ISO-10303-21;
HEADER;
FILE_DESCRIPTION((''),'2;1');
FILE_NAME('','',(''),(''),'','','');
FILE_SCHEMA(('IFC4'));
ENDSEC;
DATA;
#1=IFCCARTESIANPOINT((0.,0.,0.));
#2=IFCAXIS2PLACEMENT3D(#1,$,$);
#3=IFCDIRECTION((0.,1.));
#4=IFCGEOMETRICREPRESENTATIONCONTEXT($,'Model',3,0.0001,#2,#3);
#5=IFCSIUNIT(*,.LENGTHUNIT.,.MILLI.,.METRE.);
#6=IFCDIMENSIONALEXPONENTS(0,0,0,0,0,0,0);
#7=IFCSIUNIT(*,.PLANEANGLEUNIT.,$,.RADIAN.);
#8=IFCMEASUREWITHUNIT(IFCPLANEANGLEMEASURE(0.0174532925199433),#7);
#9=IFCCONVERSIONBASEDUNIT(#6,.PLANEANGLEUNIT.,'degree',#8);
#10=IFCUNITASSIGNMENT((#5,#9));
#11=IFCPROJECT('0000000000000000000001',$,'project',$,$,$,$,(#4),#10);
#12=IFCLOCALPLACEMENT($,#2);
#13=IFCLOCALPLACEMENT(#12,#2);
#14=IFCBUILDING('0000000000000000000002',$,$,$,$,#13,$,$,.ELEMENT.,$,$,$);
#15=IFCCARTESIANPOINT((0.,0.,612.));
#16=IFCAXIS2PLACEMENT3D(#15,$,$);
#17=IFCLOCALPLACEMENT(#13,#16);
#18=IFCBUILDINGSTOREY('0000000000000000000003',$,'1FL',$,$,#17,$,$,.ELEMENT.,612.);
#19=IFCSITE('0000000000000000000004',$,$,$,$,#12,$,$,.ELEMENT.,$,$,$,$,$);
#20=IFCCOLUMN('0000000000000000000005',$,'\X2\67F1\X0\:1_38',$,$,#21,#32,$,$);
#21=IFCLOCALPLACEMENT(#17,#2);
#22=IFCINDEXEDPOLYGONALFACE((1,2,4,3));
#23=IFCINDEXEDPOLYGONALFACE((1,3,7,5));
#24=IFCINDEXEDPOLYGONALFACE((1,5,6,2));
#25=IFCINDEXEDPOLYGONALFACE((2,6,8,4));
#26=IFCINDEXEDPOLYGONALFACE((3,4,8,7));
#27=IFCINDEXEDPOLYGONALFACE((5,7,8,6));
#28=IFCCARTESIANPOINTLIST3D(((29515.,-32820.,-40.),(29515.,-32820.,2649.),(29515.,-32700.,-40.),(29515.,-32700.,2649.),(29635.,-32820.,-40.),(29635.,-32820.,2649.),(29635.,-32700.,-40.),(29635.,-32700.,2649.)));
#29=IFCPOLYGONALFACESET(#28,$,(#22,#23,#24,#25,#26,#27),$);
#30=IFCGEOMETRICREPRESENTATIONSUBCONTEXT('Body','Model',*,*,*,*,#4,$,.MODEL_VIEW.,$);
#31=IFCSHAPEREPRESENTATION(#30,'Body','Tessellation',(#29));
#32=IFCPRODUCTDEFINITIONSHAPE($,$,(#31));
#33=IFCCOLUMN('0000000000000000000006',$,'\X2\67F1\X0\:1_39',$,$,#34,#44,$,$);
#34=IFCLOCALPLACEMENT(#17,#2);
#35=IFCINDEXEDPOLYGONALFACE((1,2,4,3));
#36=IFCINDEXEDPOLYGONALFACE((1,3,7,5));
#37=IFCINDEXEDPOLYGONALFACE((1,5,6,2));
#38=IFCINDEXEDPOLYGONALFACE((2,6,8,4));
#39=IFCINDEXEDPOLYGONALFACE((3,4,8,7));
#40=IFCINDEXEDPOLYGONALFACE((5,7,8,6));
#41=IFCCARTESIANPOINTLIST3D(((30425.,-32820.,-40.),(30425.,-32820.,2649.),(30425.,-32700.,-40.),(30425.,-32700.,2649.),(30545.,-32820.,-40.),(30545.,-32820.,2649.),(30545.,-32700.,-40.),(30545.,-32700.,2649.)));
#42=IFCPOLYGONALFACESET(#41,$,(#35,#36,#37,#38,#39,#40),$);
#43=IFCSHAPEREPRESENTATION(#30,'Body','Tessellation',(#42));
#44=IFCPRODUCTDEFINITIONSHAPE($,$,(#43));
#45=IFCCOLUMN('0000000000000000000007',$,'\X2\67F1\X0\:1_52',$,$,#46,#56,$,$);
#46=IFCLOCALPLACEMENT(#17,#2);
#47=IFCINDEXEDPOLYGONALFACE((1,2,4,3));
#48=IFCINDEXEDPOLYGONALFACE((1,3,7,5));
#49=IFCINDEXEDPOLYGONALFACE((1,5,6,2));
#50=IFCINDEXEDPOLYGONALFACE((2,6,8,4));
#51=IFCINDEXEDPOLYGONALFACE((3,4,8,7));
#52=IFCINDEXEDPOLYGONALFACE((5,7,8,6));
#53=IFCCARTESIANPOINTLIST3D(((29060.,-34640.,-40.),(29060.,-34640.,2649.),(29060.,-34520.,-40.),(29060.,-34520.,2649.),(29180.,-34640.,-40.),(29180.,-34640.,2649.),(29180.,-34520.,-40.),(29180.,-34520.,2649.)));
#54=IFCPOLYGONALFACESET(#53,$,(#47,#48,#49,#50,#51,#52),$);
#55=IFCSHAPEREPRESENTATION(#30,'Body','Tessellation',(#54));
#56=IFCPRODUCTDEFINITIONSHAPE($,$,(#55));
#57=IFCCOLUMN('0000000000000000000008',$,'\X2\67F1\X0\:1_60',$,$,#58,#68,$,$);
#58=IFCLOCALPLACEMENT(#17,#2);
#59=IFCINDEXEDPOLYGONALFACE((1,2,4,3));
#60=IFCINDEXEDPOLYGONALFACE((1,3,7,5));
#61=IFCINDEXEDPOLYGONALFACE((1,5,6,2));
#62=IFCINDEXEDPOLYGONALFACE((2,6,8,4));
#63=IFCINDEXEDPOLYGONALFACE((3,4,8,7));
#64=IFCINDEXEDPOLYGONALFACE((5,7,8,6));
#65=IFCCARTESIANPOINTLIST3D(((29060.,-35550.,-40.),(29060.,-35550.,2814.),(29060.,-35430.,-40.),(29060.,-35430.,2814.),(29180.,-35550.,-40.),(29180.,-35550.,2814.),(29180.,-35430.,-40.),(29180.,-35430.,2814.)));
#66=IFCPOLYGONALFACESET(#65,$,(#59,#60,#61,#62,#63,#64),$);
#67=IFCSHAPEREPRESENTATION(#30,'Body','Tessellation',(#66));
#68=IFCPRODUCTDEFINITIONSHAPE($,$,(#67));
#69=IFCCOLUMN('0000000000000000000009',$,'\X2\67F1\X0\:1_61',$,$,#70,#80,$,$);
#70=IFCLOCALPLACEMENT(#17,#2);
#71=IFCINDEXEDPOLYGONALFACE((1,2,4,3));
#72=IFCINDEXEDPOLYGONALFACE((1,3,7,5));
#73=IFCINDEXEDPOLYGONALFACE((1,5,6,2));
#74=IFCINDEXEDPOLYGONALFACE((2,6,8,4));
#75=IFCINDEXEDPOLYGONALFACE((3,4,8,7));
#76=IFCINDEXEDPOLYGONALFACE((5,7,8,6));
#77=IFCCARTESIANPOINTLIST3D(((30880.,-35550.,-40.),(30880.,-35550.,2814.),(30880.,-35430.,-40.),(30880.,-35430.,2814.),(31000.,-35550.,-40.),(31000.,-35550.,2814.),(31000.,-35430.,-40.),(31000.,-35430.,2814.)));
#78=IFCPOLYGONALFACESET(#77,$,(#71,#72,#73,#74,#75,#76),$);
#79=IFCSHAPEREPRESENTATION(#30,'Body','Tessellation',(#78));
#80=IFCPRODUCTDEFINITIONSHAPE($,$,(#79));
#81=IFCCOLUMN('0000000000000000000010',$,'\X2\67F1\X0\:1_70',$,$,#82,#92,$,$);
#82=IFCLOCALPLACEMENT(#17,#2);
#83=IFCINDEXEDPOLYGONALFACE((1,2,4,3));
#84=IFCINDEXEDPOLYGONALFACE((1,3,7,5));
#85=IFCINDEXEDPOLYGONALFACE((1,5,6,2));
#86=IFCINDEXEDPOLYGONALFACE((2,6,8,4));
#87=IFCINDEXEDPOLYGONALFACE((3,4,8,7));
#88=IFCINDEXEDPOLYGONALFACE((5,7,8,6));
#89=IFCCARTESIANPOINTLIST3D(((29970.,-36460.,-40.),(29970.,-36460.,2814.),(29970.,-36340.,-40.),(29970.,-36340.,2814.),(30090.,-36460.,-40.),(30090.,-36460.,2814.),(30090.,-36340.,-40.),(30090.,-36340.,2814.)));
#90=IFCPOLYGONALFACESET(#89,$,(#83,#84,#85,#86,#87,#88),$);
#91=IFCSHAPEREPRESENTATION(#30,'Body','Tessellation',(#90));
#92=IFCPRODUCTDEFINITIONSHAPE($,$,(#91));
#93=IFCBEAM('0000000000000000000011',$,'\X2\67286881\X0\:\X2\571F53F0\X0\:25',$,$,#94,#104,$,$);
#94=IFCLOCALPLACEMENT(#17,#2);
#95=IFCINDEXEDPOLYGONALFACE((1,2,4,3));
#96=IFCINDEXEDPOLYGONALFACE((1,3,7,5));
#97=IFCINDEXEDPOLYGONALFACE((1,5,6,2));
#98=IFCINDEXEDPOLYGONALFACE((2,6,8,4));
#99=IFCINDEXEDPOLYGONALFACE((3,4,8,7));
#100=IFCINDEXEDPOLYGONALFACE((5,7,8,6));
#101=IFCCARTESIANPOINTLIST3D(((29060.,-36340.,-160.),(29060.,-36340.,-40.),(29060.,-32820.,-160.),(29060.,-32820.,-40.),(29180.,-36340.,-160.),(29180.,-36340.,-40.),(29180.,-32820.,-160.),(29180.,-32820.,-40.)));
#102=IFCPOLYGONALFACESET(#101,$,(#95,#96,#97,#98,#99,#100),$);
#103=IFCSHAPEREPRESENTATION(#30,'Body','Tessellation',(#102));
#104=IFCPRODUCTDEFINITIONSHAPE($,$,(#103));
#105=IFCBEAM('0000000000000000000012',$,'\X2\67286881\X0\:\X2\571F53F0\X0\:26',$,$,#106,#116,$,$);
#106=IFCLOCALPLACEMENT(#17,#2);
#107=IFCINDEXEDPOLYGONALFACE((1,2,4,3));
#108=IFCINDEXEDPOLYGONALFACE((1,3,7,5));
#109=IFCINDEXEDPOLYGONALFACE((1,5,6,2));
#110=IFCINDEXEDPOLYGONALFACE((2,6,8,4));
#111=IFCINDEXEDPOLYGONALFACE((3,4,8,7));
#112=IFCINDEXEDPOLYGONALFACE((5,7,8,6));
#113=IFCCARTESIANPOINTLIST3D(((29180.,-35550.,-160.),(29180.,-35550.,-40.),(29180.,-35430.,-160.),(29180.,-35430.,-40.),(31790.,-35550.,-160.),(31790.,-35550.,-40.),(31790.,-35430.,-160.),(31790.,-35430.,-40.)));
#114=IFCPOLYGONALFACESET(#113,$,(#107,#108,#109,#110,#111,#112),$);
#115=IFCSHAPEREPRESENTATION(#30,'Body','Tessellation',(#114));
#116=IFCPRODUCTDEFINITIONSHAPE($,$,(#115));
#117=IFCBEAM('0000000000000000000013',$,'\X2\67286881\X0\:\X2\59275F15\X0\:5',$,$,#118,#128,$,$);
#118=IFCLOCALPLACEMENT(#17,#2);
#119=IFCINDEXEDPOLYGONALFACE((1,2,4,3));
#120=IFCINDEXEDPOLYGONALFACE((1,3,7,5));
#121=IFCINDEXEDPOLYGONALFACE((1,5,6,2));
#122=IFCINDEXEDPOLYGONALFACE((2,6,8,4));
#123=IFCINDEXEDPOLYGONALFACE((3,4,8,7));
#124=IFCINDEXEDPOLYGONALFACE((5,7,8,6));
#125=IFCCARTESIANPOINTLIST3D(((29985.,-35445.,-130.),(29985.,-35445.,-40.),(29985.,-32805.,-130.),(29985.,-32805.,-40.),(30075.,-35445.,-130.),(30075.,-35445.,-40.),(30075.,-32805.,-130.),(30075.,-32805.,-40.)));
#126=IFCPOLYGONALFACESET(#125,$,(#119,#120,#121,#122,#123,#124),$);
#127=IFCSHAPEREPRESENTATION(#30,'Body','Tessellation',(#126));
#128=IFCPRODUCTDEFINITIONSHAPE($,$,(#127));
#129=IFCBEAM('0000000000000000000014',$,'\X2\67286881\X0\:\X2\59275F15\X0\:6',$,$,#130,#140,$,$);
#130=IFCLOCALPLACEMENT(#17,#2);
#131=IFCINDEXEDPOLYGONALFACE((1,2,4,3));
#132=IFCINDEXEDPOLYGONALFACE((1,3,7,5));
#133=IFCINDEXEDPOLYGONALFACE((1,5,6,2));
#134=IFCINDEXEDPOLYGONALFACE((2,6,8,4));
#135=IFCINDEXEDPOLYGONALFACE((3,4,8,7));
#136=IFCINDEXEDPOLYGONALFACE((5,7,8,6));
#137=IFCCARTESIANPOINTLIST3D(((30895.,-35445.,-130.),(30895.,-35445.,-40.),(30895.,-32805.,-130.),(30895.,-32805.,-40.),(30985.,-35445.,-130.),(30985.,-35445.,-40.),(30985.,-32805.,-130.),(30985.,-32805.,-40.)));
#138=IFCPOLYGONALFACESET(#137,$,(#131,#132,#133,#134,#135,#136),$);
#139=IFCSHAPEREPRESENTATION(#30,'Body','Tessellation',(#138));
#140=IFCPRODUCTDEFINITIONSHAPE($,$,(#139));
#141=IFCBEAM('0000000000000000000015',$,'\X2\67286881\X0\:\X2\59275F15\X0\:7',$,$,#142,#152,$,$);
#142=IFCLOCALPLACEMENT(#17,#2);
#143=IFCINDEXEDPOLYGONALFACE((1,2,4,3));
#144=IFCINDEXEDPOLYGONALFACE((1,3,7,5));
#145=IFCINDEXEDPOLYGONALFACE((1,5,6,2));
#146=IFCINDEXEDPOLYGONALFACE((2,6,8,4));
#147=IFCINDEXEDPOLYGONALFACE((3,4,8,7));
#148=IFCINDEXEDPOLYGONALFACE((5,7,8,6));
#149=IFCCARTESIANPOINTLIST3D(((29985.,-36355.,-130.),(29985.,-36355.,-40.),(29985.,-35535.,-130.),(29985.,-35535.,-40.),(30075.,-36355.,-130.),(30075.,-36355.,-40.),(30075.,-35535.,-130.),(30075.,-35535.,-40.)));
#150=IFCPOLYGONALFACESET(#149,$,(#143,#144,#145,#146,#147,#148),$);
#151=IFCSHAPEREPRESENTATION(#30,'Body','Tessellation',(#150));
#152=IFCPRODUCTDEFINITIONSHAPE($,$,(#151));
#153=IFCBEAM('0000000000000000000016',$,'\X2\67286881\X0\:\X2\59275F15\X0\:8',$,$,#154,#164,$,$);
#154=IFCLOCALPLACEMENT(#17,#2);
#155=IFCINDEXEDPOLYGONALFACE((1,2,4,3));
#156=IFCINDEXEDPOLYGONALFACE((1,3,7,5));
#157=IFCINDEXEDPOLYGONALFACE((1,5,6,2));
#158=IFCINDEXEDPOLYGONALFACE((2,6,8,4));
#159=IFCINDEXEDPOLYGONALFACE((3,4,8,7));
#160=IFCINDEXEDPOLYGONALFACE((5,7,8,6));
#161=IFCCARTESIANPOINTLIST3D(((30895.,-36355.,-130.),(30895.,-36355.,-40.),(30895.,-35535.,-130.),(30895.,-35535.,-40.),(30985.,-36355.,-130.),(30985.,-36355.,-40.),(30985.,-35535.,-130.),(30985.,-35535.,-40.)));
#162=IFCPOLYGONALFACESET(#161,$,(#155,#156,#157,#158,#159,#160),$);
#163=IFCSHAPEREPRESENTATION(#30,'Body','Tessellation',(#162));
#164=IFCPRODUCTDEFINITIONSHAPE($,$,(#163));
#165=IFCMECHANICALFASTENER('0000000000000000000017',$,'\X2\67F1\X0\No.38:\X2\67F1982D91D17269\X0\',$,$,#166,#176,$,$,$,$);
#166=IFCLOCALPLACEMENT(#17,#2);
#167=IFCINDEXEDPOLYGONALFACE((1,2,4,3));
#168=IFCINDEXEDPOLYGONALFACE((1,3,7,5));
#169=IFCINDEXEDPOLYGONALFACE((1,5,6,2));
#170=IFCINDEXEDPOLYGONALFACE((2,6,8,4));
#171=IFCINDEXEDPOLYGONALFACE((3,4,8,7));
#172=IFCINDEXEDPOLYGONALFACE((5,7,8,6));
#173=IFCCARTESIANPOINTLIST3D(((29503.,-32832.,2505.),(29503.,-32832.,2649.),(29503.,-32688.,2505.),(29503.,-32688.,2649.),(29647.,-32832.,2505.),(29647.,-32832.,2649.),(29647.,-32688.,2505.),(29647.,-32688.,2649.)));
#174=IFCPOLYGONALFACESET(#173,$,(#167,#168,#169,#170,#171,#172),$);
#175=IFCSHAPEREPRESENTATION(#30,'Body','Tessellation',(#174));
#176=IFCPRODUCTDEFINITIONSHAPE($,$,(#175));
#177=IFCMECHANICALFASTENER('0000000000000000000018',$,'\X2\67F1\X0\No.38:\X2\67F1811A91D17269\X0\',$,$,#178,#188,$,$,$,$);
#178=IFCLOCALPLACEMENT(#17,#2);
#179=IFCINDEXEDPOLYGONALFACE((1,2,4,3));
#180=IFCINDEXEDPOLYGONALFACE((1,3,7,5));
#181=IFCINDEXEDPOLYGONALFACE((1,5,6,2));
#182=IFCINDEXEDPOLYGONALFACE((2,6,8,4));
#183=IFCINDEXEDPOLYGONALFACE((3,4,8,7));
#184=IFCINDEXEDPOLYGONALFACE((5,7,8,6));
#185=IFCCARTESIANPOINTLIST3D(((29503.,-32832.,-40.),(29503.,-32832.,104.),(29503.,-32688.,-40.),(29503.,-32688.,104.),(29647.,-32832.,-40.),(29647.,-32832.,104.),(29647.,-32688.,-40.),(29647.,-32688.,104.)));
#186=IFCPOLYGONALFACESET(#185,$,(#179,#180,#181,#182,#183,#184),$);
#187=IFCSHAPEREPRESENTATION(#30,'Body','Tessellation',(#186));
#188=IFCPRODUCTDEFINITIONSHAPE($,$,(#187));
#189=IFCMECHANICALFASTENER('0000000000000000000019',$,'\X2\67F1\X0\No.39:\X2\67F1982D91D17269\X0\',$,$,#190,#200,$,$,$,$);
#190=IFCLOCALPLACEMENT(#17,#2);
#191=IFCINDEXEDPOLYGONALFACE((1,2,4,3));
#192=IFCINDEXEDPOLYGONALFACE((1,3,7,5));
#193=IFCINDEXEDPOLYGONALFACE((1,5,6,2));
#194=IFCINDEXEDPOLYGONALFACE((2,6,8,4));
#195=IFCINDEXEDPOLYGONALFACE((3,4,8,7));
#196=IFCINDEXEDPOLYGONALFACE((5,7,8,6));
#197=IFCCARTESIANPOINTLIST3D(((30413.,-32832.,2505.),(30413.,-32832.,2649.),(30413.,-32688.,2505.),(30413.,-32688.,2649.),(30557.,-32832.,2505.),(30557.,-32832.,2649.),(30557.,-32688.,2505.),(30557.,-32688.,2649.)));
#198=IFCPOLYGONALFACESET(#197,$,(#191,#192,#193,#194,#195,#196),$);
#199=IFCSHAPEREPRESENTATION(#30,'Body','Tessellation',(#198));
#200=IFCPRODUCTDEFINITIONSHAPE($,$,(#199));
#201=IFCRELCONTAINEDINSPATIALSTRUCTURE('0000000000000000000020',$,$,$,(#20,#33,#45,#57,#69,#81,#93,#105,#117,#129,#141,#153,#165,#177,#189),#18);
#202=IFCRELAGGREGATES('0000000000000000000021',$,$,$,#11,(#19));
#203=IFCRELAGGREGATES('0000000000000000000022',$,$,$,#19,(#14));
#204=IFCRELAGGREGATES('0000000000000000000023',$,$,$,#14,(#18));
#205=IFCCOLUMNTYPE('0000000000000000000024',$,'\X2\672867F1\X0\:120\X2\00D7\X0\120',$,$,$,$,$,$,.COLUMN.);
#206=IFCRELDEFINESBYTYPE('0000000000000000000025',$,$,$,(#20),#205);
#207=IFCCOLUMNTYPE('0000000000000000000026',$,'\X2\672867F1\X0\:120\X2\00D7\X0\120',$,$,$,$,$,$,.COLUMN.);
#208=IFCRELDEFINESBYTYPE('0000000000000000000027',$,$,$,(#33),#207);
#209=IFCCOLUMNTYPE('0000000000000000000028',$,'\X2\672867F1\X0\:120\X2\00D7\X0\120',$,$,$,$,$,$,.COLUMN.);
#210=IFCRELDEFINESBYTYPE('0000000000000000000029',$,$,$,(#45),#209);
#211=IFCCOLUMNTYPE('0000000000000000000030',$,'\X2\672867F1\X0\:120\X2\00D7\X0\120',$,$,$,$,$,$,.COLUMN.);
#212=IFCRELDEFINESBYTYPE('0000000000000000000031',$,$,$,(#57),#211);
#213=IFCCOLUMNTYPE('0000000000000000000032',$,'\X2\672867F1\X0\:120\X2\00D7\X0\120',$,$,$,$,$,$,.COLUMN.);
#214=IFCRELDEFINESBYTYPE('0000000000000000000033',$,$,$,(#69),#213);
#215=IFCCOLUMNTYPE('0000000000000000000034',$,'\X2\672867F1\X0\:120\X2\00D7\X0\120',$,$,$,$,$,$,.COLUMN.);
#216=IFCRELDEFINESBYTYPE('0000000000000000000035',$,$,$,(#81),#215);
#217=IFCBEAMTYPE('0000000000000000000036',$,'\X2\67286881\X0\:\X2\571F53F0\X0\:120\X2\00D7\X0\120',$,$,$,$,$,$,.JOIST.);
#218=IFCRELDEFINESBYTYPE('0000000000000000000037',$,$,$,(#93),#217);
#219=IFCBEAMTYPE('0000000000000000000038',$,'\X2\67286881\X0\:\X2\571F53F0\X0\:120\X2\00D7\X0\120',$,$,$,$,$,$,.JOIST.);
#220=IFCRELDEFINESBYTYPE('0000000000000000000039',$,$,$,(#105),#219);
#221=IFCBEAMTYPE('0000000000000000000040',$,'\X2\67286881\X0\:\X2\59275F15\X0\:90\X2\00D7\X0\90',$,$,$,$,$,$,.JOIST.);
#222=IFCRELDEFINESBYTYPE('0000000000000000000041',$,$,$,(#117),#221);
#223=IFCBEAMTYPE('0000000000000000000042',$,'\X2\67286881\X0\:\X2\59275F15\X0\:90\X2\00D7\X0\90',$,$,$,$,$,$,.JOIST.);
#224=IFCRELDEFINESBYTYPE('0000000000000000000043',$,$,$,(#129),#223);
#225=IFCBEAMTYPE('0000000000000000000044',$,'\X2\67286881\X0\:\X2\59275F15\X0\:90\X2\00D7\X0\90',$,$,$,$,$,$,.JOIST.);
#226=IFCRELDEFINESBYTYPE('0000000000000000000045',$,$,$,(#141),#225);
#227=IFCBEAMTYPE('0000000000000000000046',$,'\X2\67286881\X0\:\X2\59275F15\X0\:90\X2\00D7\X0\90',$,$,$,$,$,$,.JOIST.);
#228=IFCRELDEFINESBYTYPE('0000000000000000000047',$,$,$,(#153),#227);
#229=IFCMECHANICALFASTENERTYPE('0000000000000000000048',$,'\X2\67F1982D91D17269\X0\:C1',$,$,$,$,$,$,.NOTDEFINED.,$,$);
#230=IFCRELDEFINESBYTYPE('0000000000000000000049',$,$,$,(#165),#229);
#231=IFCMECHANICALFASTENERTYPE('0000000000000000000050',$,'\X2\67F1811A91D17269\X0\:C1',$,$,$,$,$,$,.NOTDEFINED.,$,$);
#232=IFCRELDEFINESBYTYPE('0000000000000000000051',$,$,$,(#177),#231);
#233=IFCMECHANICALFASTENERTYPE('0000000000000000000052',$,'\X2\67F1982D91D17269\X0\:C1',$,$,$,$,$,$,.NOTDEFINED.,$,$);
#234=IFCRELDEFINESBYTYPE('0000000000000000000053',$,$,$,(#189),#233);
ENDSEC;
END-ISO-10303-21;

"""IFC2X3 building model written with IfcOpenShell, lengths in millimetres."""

from ifc_helpers import new_model, entity, si_unit, converted_unit, direction, frame, origin, origin_with_axes, origin_2d, place, context, subcontext, project, spatial, rectangle, extrude, type_object, element, save


model = new_model("IFC2X3")

# Units and contexts
model_context = context("Model", 3, precision=0.0001, world=origin(), true_north=direction((0.0, 1.0)))
body_context = subcontext(model_context, "Body", "Model", "MODEL_VIEW")
ifc_project = project(units=[si_unit("LENGTHUNIT", "METRE", prefix="MILLI"), converted_unit("PLANEANGLEUNIT", "degree", entity("IfcPlaneAngleMeasure", 0.0174532925199433), si_unit("PLANEANGLEUNIT", "RADIAN"), dimensions=[0, 0, 0, 0, 0, 0, 0])], contexts=[model_context])

# Site, building, storey
site_placement = place(None, origin())
site = spatial("IfcSite", under=ifc_project, at=site_placement, CompositionType="ELEMENT")
building_placement = place(site_placement, origin())
building = spatial("IfcBuilding", under=site, at=building_placement, CompositionType="ELEMENT")
storey_placement = place(building_placement, frame((0.0, 0.0, 612.0)))
storey = spatial("IfcBuildingStorey", under=building, at=storey_placement, Name="1FL", CompositionType="ELEMENT", Elevation=612.0)

# Columns
column_type_1 = type_object("IfcColumnType", Name="木柱:120×120", PredefinedType="COLUMN")
column_1_placement = place(storey_placement, frame((29575.0, -32760.0, -40.0)))
element("IfcColumn", 1, at=column_1_placement, inside=storey, type_object=column_type_1, Name="柱:1_38", context=body_context, shape_type="SweptSolid", body=[
    extrude(rectangle(XDim=120.0, YDim=120.0, at=origin_2d()), origin_with_axes(), (0.0, 0.0, 1.0), 2689.0),
])
column_type_2 = type_object("IfcColumnType", Name="木柱:120×120", PredefinedType="COLUMN")
column_2_placement = place(storey_placement, frame((30485.0, -32760.0, -40.0)))
element("IfcColumn", 2, at=column_2_placement, inside=storey, type_object=column_type_2, Name="柱:1_39", context=body_context, shape_type="SweptSolid", body=[
    extrude(rectangle(XDim=120.0, YDim=120.0, at=origin_2d()), origin_with_axes(), (0.0, 0.0, 1.0), 2689.0),
])
column_type_3 = type_object("IfcColumnType", Name="木柱:120×120", PredefinedType="COLUMN")
column_3_placement = place(storey_placement, frame((29120.0, -34580.0, -40.0)))
element("IfcColumn", 3, at=column_3_placement, inside=storey, type_object=column_type_3, Name="柱:1_52", context=body_context, shape_type="SweptSolid", body=[
    extrude(rectangle(XDim=120.0, YDim=120.0, at=origin_2d()), origin_with_axes(), (0.0, 0.0, 1.0), 2689.0),
])
column_type_4 = type_object("IfcColumnType", Name="木柱:120×120", PredefinedType="COLUMN")
column_4_placement = place(storey_placement, frame((29120.0, -35490.0, -40.0)))
element("IfcColumn", 4, at=column_4_placement, inside=storey, type_object=column_type_4, Name="柱:1_60", context=body_context, shape_type="SweptSolid", body=[
    extrude(rectangle(XDim=120.0, YDim=120.0, at=origin_2d()), origin_with_axes(), (0.0, 0.0, 1.0), 2854.0),
])
column_type_5 = type_object("IfcColumnType", Name="木柱:120×120", PredefinedType="COLUMN")
column_5_placement = place(storey_placement, frame((30940.0, -35490.0, -40.0)))
element("IfcColumn", 5, at=column_5_placement, inside=storey, type_object=column_type_5, Name="柱:1_61", context=body_context, shape_type="SweptSolid", body=[
    extrude(rectangle(XDim=120.0, YDim=120.0, at=origin_2d()), origin_with_axes(), (0.0, 0.0, 1.0), 2854.0),
])
column_type_6 = type_object("IfcColumnType", Name="木柱:120×120", PredefinedType="COLUMN")
column_6_placement = place(storey_placement, frame((30030.0, -36400.0, -40.0)))
element("IfcColumn", 6, at=column_6_placement, inside=storey, type_object=column_type_6, Name="柱:1_70", context=body_context, shape_type="SweptSolid", body=[
    extrude(rectangle(XDim=120.0, YDim=120.0, at=origin_2d()), origin_with_axes(), (0.0, 0.0, 1.0), 2854.0),
])

# Beams
beam_type_1 = type_object("IfcBeamType", Name="木梁:土台:120×120", PredefinedType="JOIST")
beam_1_placement = place(storey_placement, frame((29120.0, -32820.0, -100.0), z_axis=(0.0, -1.0, 0.0), x_axis=(1.0, 0.0, 0.0)))
element("IfcBeam", 7, at=beam_1_placement, inside=storey, type_object=beam_type_1, Name="木梁:土台:25", context=body_context, shape_type="SweptSolid", body=[
    extrude(rectangle(XDim=120.0, YDim=120.0, at=origin_2d()), origin_with_axes(), (0.0, 0.0, 1.0), 3520.0),
])
beam_type_2 = type_object("IfcBeamType", Name="木梁:土台:120×120", PredefinedType="JOIST")
beam_2_placement = place(storey_placement, frame((29180.0, -35490.0, -100.0), z_axis=(1.0, 0.0, 0.0), x_axis=(0.0, 1.0, 0.0)))
element("IfcBeam", 8, at=beam_2_placement, inside=storey, type_object=beam_type_2, Name="木梁:土台:26", context=body_context, shape_type="SweptSolid", body=[
    extrude(rectangle(XDim=120.0, YDim=120.0, at=origin_2d()), origin_with_axes(), (0.0, 0.0, 1.0), 2610.0),
])
beam_type_3 = type_object("IfcBeamType", Name="木梁:大引:90×90", PredefinedType="JOIST")
beam_3_placement = place(storey_placement, frame((30030.0, -32805.0, -85.0), z_axis=(0.0, -1.0, 0.0), x_axis=(1.0, 0.0, 0.0)))
element("IfcBeam", 9, at=beam_3_placement, inside=storey, type_object=beam_type_3, Name="木梁:大引:5", context=body_context, shape_type="SweptSolid", body=[
    extrude(rectangle(XDim=90.0, YDim=90.0, at=origin_2d()), origin_with_axes(), (0.0, 0.0, 1.0), 2640.0),
])
beam_type_4 = type_object("IfcBeamType", Name="木梁:大引:90×90", PredefinedType="JOIST")
beam_4_placement = place(storey_placement, frame((30940.0, -32805.0, -85.0), z_axis=(0.0, -1.0, 0.0), x_axis=(1.0, 0.0, 0.0)))
element("IfcBeam", 10, at=beam_4_placement, inside=storey, type_object=beam_type_4, Name="木梁:大引:6", context=body_context, shape_type="SweptSolid", body=[
    extrude(rectangle(XDim=90.0, YDim=90.0, at=origin_2d()), origin_with_axes(), (0.0, 0.0, 1.0), 2640.0),
])
beam_type_5 = type_object("IfcBeamType", Name="木梁:大引:90×90", PredefinedType="JOIST")
beam_5_placement = place(storey_placement, frame((30030.0, -35535.0, -85.0), z_axis=(0.0, -1.0, 0.0), x_axis=(1.0, 0.0, 0.0)))
element("IfcBeam", 11, at=beam_5_placement, inside=storey, type_object=beam_type_5, Name="木梁:大引:7", context=body_context, shape_type="SweptSolid", body=[
    extrude(rectangle(XDim=90.0, YDim=90.0, at=origin_2d()), origin_with_axes(), (0.0, 0.0, 1.0), 820.0),
])
beam_type_6 = type_object("IfcBeamType", Name="木梁:大引:90×90", PredefinedType="JOIST")
beam_6_placement = place(storey_placement, frame((30940.0, -35535.0, -85.0), z_axis=(0.0, -1.0, 0.0), x_axis=(1.0, 0.0, 0.0)))
element("IfcBeam", 12, at=beam_6_placement, inside=storey, type_object=beam_type_6, Name="木梁:大引:8", context=body_context, shape_type="SweptSolid", body=[
    extrude(rectangle(XDim=90.0, YDim=90.0, at=origin_2d()), origin_with_axes(), (0.0, 0.0, 1.0), 820.0),
])

# Mechanical fasteners
mechanical_fastener_type_1 = type_object("IfcMechanicalFastenerType", Name="柱頭金物:C1")
mechanical_fastener_1_placement = place(storey_placement, frame((29575.0, -32760.0, 2505.0)))
element("IfcMechanicalFastener", 13, at=mechanical_fastener_1_placement, inside=storey, type_object=mechanical_fastener_type_1, Name="柱No.38:柱頭金物", context=body_context, shape_type="SweptSolid", body=[
    extrude(rectangle(XDim=144.0, YDim=144.0, at=origin_2d()), origin_with_axes(), (0.0, 0.0, 1.0), 144.0),
])
mechanical_fastener_type_2 = type_object("IfcMechanicalFastenerType", Name="柱脚金物:C1")
mechanical_fastener_2_placement = place(storey_placement, frame((29575.0, -32760.0, -40.0)))
element("IfcMechanicalFastener", 14, at=mechanical_fastener_2_placement, inside=storey, type_object=mechanical_fastener_type_2, Name="柱No.38:柱脚金物", context=body_context, shape_type="SweptSolid", body=[
    extrude(rectangle(XDim=144.0, YDim=144.0, at=origin_2d()), origin_with_axes(), (0.0, 0.0, 1.0), 144.0),
])
mechanical_fastener_type_3 = type_object("IfcMechanicalFastenerType", Name="柱頭金物:C1")
mechanical_fastener_3_placement = place(storey_placement, frame((30485.0, -32760.0, 2505.0)))
element("IfcMechanicalFastener", 15, at=mechanical_fastener_3_placement, inside=storey, type_object=mechanical_fastener_type_3, Name="柱No.39:柱頭金物", context=body_context, shape_type="SweptSolid", body=[
    extrude(rectangle(XDim=144.0, YDim=144.0, at=origin_2d()), origin_with_axes(), (0.0, 0.0, 1.0), 144.0),
])

save(model, "model.ifc")
